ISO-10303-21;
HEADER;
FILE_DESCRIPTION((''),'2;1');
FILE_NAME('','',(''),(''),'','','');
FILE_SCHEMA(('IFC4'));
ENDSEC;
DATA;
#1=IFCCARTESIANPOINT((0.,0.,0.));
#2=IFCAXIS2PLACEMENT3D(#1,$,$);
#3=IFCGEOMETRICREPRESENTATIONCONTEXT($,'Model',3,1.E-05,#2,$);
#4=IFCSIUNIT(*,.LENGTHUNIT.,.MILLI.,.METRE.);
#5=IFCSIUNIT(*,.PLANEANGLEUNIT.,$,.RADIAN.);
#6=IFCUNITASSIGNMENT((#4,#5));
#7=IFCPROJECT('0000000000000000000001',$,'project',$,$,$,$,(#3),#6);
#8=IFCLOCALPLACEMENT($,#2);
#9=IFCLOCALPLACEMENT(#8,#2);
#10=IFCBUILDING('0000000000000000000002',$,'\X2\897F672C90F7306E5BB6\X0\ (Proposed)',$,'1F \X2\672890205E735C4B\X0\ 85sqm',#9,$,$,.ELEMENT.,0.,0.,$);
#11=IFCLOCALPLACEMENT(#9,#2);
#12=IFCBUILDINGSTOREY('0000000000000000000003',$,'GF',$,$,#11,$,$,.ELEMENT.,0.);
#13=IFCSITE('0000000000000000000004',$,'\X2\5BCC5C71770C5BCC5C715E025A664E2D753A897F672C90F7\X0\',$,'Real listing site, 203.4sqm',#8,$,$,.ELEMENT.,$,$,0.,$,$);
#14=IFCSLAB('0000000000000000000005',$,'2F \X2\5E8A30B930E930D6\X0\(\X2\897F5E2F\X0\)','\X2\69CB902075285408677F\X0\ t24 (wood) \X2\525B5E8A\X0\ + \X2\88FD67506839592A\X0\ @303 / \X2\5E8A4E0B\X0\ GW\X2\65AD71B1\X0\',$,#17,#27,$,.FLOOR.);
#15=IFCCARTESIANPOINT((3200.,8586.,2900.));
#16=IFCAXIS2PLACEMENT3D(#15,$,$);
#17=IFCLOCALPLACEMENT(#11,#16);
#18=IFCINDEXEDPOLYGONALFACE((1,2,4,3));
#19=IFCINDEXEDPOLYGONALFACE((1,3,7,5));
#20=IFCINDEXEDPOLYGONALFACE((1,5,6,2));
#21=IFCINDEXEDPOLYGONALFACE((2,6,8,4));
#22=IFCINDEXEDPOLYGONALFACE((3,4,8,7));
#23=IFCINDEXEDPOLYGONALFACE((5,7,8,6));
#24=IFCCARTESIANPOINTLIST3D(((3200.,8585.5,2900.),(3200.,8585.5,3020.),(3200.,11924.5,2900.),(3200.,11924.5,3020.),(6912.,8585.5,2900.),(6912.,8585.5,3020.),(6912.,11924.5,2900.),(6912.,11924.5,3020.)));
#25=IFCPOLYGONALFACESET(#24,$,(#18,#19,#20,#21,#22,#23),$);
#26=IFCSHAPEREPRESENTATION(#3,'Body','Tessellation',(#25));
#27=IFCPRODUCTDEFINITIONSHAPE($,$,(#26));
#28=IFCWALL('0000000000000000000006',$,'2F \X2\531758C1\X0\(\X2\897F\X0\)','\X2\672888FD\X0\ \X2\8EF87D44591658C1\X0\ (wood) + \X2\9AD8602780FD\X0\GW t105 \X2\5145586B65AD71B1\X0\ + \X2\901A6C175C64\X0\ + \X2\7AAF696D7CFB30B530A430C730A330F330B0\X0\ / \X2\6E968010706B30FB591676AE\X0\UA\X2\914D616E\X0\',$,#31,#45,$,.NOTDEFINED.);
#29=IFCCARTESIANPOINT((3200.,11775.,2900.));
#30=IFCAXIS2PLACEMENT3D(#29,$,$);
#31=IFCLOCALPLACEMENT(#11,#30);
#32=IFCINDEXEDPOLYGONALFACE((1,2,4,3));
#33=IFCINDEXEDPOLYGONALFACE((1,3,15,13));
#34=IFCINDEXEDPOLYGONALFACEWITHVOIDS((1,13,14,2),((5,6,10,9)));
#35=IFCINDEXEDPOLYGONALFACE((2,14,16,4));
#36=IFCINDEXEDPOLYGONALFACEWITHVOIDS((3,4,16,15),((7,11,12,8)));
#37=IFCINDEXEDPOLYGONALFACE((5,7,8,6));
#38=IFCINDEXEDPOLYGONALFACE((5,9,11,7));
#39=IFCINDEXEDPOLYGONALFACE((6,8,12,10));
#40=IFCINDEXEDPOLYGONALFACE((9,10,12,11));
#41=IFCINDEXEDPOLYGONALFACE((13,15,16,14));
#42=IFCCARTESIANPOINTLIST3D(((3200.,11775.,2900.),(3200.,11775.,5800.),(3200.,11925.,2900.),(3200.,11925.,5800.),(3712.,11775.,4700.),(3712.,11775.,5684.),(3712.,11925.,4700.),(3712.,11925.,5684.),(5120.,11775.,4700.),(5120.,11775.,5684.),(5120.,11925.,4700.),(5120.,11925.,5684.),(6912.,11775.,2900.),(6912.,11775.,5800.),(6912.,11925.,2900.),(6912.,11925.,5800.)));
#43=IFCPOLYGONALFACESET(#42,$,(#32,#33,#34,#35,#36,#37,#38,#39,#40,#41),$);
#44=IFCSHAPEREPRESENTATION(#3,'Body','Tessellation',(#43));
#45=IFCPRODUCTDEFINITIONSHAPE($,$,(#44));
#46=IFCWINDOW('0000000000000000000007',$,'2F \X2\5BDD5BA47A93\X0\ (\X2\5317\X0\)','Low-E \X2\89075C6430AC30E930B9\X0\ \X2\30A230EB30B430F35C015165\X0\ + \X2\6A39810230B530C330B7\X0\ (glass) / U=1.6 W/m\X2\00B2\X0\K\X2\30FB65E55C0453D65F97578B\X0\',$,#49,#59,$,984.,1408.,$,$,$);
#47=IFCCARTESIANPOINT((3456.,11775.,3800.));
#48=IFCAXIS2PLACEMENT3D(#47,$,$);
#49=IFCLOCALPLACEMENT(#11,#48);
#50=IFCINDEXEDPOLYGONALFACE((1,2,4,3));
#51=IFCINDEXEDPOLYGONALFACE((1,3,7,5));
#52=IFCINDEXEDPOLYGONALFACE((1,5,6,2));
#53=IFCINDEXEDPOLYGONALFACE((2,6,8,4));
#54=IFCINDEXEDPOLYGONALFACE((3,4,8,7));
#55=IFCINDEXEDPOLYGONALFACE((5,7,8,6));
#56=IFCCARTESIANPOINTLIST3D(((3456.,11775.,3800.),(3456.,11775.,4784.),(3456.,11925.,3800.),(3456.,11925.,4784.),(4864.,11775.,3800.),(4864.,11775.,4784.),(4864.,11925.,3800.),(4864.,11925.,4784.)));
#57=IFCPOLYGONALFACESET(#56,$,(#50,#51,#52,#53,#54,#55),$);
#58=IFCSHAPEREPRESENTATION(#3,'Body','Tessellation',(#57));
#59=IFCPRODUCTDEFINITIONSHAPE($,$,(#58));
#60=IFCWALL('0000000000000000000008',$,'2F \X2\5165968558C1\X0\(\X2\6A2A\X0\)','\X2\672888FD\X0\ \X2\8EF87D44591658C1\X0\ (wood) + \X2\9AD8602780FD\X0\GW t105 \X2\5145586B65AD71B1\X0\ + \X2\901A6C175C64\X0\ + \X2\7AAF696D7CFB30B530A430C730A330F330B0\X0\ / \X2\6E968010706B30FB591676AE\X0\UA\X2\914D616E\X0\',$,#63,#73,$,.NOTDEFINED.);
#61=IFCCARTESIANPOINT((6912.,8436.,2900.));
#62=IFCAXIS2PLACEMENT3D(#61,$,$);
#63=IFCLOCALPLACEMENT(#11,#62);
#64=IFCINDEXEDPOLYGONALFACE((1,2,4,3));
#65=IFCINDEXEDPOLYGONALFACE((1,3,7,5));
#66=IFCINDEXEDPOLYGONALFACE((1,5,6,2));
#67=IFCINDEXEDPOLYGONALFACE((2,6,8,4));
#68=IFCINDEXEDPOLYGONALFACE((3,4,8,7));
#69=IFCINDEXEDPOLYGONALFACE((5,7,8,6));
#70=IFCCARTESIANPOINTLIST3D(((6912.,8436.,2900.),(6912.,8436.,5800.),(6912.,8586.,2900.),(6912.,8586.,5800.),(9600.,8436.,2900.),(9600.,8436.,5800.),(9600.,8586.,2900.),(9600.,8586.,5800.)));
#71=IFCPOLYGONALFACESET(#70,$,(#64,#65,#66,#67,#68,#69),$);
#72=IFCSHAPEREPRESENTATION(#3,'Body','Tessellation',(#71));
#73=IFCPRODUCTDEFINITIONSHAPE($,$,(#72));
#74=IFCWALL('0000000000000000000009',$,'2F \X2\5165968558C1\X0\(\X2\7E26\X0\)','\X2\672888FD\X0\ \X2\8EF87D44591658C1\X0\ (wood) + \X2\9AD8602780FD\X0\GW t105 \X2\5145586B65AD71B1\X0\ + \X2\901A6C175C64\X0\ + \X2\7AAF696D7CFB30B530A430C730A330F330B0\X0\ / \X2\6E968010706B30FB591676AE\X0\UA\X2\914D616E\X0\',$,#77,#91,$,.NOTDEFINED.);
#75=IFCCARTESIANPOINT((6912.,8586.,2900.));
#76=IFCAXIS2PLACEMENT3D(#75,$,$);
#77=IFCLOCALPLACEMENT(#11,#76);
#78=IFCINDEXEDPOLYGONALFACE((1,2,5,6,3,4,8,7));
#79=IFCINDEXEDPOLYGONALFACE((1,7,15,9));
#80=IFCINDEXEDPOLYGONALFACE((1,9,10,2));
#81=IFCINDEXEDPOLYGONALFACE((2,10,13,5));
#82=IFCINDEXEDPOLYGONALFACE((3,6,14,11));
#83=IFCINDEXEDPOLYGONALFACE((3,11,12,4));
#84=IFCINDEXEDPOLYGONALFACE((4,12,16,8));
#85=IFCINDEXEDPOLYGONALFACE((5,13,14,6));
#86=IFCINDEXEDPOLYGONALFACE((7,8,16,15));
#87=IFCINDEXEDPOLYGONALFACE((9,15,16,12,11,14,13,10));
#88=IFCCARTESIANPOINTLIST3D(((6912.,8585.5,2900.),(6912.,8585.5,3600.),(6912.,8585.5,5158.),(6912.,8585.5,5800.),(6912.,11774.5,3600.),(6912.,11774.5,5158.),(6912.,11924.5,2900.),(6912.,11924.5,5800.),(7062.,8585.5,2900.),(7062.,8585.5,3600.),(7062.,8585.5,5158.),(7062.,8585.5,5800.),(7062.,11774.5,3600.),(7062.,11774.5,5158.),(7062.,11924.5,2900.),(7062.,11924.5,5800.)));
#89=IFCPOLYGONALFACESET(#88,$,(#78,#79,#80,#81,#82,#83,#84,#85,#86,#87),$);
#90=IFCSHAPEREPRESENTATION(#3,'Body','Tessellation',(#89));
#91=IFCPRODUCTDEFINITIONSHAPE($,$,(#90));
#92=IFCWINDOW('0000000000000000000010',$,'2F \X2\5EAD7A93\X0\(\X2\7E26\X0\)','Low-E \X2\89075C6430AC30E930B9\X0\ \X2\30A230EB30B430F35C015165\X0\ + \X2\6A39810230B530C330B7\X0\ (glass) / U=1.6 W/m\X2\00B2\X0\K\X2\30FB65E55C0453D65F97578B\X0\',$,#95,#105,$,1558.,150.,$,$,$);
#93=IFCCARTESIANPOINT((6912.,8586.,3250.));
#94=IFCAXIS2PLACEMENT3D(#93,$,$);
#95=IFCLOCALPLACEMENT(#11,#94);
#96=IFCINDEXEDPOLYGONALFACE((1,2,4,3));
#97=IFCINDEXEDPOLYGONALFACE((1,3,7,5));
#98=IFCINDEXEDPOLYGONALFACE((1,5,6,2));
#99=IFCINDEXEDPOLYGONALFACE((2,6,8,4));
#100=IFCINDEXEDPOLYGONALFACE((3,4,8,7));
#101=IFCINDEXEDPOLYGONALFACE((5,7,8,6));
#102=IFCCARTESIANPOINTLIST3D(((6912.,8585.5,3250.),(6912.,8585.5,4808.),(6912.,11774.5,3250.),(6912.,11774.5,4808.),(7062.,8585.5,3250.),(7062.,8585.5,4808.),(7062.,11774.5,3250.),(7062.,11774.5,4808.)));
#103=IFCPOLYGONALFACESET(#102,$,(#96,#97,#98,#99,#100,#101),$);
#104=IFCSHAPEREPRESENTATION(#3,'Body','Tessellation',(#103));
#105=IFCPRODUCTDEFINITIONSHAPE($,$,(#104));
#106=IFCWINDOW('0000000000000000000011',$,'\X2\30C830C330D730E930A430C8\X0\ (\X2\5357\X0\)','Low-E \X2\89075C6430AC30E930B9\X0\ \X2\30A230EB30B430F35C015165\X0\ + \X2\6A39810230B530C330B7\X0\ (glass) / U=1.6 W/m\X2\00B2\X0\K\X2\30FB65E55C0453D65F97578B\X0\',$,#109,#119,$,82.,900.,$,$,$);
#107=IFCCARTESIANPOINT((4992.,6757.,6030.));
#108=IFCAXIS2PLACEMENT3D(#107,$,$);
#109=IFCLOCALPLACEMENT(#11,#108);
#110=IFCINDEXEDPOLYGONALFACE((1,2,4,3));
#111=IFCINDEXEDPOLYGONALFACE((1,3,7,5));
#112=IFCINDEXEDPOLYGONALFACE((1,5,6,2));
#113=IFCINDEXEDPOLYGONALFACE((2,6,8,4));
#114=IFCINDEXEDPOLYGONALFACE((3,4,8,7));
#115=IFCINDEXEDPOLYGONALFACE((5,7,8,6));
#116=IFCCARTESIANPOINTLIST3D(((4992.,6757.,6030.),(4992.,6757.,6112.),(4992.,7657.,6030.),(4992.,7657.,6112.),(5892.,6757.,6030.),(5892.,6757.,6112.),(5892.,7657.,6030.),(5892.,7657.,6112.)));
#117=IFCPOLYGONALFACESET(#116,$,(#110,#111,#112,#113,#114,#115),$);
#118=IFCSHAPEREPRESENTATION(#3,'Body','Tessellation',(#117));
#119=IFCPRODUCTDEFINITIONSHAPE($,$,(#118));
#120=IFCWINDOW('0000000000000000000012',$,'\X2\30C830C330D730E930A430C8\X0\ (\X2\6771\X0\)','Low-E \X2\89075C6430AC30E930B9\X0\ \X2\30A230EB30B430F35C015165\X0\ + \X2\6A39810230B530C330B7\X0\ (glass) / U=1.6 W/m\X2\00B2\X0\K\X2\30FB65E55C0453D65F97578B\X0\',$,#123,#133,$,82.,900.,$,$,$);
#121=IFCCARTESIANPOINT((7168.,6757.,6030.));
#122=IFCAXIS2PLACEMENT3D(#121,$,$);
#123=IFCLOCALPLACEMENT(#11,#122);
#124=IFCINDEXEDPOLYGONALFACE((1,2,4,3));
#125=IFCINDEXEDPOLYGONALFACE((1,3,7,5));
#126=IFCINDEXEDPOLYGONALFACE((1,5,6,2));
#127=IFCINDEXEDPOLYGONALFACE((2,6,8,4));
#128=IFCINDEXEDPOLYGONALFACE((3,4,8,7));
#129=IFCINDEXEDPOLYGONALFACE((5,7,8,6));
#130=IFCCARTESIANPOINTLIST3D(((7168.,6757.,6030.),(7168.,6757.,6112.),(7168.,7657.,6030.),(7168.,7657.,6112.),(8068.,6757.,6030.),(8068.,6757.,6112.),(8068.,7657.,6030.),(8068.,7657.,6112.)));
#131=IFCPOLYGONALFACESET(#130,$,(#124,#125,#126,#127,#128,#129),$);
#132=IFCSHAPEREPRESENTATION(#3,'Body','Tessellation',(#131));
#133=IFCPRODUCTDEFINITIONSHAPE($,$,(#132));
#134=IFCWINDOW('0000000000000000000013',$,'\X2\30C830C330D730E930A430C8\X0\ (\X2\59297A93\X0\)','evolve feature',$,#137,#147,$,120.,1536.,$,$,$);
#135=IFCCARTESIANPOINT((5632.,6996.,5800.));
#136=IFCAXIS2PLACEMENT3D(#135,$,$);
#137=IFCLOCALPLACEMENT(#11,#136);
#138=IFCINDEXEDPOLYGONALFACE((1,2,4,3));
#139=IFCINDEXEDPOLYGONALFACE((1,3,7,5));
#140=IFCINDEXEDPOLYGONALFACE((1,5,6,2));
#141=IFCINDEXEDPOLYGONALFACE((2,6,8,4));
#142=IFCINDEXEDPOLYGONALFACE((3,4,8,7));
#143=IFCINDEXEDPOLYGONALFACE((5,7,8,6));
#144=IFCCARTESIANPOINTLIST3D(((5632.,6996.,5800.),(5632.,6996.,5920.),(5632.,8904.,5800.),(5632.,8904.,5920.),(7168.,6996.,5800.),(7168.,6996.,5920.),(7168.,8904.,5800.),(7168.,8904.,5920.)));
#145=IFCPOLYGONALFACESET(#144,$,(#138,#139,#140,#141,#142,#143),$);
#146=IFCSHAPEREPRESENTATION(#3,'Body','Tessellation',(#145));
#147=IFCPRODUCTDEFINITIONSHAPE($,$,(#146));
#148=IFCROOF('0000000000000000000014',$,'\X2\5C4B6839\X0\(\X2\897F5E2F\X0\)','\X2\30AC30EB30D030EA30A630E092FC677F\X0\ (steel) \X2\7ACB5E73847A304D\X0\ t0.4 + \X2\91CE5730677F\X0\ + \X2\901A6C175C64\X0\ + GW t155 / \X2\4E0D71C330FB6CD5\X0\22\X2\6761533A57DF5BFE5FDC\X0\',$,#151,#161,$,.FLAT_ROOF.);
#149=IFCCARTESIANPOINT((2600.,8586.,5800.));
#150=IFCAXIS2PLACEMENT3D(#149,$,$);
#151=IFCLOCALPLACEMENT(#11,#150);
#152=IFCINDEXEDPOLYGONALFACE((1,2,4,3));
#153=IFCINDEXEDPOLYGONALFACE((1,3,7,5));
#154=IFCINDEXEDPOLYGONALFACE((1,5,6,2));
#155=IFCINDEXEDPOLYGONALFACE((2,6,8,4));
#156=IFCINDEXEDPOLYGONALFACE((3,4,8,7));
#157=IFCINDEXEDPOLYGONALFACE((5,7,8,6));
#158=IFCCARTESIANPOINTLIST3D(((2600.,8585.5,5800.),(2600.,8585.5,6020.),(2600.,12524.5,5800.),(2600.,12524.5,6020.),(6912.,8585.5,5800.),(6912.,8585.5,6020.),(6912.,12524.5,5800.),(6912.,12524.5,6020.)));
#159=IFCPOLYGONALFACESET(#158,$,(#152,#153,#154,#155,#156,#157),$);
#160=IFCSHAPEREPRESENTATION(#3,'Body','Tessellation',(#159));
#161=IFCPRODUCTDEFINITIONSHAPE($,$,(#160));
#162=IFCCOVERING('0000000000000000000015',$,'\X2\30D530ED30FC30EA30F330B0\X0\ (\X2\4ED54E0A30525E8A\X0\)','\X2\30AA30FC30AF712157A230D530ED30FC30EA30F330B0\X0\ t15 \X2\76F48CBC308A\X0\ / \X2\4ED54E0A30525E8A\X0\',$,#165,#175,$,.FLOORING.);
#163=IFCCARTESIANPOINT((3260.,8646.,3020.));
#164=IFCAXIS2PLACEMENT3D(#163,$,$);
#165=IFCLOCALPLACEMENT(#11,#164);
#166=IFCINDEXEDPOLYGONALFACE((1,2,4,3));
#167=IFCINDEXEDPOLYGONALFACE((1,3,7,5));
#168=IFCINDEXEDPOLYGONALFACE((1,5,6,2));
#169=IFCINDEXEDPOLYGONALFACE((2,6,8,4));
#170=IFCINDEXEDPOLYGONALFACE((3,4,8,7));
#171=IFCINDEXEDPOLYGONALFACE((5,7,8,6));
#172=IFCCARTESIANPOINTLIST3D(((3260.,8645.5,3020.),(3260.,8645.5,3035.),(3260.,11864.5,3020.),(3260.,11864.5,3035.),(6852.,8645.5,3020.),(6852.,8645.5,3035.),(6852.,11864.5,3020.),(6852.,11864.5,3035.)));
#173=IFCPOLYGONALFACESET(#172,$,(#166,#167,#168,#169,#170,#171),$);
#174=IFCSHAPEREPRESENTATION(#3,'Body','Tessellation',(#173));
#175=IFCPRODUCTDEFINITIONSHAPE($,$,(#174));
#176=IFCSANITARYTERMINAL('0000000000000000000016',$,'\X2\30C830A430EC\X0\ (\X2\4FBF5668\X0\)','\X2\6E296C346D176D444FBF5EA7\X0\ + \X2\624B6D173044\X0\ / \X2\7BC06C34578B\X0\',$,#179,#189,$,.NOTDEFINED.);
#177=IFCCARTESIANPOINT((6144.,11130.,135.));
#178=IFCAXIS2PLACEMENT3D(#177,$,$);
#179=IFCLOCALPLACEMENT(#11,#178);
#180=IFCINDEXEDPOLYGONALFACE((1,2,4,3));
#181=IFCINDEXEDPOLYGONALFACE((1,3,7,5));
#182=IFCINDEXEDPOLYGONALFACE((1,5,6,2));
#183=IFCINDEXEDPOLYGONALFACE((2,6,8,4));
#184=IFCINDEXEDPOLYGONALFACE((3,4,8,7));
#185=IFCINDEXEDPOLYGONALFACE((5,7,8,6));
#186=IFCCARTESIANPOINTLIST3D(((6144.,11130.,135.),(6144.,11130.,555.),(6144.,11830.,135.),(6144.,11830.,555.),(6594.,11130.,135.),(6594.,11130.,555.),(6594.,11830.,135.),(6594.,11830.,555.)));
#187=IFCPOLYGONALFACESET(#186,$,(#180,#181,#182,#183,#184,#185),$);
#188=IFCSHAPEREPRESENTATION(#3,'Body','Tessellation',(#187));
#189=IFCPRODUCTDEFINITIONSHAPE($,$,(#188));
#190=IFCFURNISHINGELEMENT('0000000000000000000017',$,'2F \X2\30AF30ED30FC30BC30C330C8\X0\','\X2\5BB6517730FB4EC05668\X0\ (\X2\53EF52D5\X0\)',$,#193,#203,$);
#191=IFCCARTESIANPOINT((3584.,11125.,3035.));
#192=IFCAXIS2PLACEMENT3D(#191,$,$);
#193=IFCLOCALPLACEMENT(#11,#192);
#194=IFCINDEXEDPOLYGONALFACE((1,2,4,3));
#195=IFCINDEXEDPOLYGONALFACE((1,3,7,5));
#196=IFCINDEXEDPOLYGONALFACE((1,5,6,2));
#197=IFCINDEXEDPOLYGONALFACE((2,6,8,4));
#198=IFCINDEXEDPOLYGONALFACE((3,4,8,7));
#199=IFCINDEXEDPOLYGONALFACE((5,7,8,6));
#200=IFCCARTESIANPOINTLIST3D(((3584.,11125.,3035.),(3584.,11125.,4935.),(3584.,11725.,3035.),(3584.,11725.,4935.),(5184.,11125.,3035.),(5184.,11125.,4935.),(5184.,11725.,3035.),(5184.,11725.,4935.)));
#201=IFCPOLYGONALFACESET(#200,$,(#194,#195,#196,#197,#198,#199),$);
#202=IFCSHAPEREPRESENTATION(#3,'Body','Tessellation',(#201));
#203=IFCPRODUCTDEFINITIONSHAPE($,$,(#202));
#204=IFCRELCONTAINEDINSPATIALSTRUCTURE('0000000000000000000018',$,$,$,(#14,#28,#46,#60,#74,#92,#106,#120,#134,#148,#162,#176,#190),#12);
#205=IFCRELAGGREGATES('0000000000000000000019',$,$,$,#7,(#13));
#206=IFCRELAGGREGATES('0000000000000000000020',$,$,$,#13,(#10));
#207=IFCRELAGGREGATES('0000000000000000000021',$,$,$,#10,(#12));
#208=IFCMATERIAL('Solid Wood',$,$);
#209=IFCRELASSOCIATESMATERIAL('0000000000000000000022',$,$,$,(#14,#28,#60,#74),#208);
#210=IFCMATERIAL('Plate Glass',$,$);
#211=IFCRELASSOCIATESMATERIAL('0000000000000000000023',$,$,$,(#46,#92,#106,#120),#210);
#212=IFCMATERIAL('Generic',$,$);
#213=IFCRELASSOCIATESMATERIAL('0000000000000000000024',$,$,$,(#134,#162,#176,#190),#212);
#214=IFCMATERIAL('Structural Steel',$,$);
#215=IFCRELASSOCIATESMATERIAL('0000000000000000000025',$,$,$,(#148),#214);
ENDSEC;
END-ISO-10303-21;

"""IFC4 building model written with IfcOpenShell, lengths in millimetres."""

from ifc_helpers import new_model, si_unit, frame, frame_2d, origin, place, context, project, spatial, rectangle, extrude, material, element, fill, save


model = new_model("IFC4")

# Units and contexts
model_context = context("Model", 3, precision=1e-05, world=origin())
ifc_project = project(units=[si_unit("LENGTHUNIT", "METRE", prefix="MILLI"), si_unit("PLANEANGLEUNIT", "RADIAN")], contexts=[model_context])

# Site, building, storey
site_placement = place(None, origin())
site = spatial("IfcSite", under=ifc_project, at=site_placement, Name="富山県富山市婦中町西本郷", ObjectType="Real listing site, 203.4sqm", CompositionType="ELEMENT", RefElevation=0.0)
building_placement = place(site_placement, origin())
building = spatial("IfcBuilding", under=site, at=building_placement, Name="西本郷の家 (Proposed)", ObjectType="1F 木造平屋 85sqm", CompositionType="ELEMENT", ElevationOfRefHeight=0.0, ElevationOfTerrain=0.0)
storey_placement = place(building_placement, origin())
storey = spatial("IfcBuildingStorey", under=building, at=storey_placement, Name="GF", CompositionType="ELEMENT", Elevation=0.0)

# Slab
ifc_material_1 = material(Name="Solid Wood")
slab_placement = place(storey_placement, frame((3200.0, 8586.0, 2900.0)))
element("IfcSlab", 1, at=slab_placement, inside=storey, material=ifc_material_1, Name="2F 床スラブ(西帯)", Description="構造用合板 t24 (wood) 剛床 + 製材根太 @303 / 床下 GW断熱", PredefinedType="FLOOR", context=model_context, shape_type="SweptSolid", body=[
    extrude(rectangle(XDim=3712.0, YDim=3339.0, at=frame_2d((1856.0, 1669.0))), frame((3200.0, 8586.0, 2900.0)), (0.0, 0.0, 1.0), 120.0),
])

# Wall, opening, window
wall_1_placement = place(storey_placement, frame((3200.0, 11775.0, 2900.0)))
wall_1 = element("IfcWall", 2, at=wall_1_placement, inside=storey, material=ifc_material_1, Name="2F 北壁(西)", Description="木製 軸組外壁 (wood) + 高性能GW t105 充填断熱 + 通気層 + 窯業系サイディング / 準耐火・外皮UA配慮", PredefinedType="NOTDEFINED", context=model_context, shape_type="SweptSolid", body=[
    extrude(rectangle(XDim=3712.0, YDim=150.0, at=frame_2d((1856.0, 75.0))), frame((3200.0, 11775.0, 2900.0)), (0.0, 0.0, 1.0), 2900.0),
])
opening_1_placement = place(storey_placement, frame((3456.0, 11775.0, 3800.0)))
opening_1 = element("IfcOpeningElement", 3, at=opening_1_placement, cuts=wall_1, PredefinedType="NOTDEFINED", context=model_context, shape_type="SweptSolid", body=[
    extrude(rectangle(XDim=1408.0, YDim=150.0, at=frame_2d((704.0, 75.0))), frame((3456.0, 11775.0, 3800.0)), (0.0, 0.0, 1.0), 984.0),
])
ifc_material_2 = material(Name="Plate Glass")
window_1_placement = place(storey_placement, frame((3456.0, 11775.0, 3800.0)))
window_1 = element("IfcWindow", 4, at=window_1_placement, inside=storey, material=ifc_material_2, Name="2F 寝室窓 (北)", Description="Low-E 複層ガラス アルゴン封入 + 樹脂サッシ (glass) / U=1.6 W/m²K・日射取得型", OverallHeight=984.0, OverallWidth=1408.0, context=model_context, shape_type="SweptSolid", body=[
    extrude(rectangle(XDim=1408.0, YDim=150.0, at=frame_2d((704.0, 75.0))), frame((3456.0, 11775.0, 3800.0)), (0.0, 0.0, 1.0), 984.0),
])
fill(opening_1, window_1)

# Wall
wall_2_placement = place(storey_placement, frame((6912.0, 8436.0, 2900.0)))
element("IfcWall", 5, at=wall_2_placement, inside=storey, material=ifc_material_1, Name="2F 入隅壁(横)", Description="木製 軸組外壁 (wood) + 高性能GW t105 充填断熱 + 通気層 + 窯業系サイディング / 準耐火・外皮UA配慮", PredefinedType="NOTDEFINED", context=model_context, shape_type="SweptSolid", body=[
    extrude(rectangle(XDim=2688.0, YDim=150.0, at=frame_2d((1344.0, 75.0))), frame((6912.0, 8436.0, 2900.0)), (0.0, 0.0, 1.0), 2900.0),
])

# Wall, opening, window
wall_3_placement = place(storey_placement, frame((6912.0, 8586.0, 2900.0)))
wall_3 = element("IfcWall", 6, at=wall_3_placement, inside=storey, material=ifc_material_1, Name="2F 入隅壁(縦)", Description="木製 軸組外壁 (wood) + 高性能GW t105 充填断熱 + 通気層 + 窯業系サイディング / 準耐火・外皮UA配慮", PredefinedType="NOTDEFINED", context=model_context, shape_type="SweptSolid", body=[
    extrude(rectangle(XDim=150.0, YDim=3339.0, at=frame_2d((75.0, 1669.0))), frame((6912.0, 8586.0, 2900.0)), (0.0, 0.0, 1.0), 2900.0),
])
opening_2_placement = place(storey_placement, frame((6912.0, 8586.0, 3250.0)))
opening_2 = element("IfcOpeningElement", 7, at=opening_2_placement, cuts=wall_3, PredefinedType="NOTDEFINED", context=model_context, shape_type="SweptSolid", body=[
    extrude(rectangle(XDim=150.0, YDim=3189.0, at=frame_2d((75.0, 1594.0))), frame((6912.0, 8586.0, 3250.0)), (0.0, 0.0, 1.0), 1558.0),
])
window_2_placement = place(storey_placement, frame((6912.0, 8586.0, 3250.0)))
window_2 = element("IfcWindow", 8, at=window_2_placement, inside=storey, material=ifc_material_2, Name="2F 庭窓(縦)", Description="Low-E 複層ガラス アルゴン封入 + 樹脂サッシ (glass) / U=1.6 W/m²K・日射取得型", OverallHeight=1558.0, OverallWidth=150.0, context=model_context, shape_type="SweptSolid", body=[
    extrude(rectangle(XDim=150.0, YDim=3189.0, at=frame_2d((75.0, 1594.0))), frame((6912.0, 8586.0, 3250.0)), (0.0, 0.0, 1.0), 1558.0),
])
fill(opening_2, window_2)

# Windows
window_3_placement = place(storey_placement, frame((4992.0, 6757.0, 6030.0)))
element("IfcWindow", 9, at=window_3_placement, inside=storey, material=ifc_material_2, Name="トップライト (南)", Description="Low-E 複層ガラス アルゴン封入 + 樹脂サッシ (glass) / U=1.6 W/m²K・日射取得型", OverallHeight=82.0, OverallWidth=900.0, context=model_context, shape_type="SweptSolid", body=[
    extrude(rectangle(XDim=900.0, YDim=900.0, at=frame_2d((450.0, 450.0))), frame((4992.0, 6757.0, 6030.0)), (0.0, 0.0, 1.0), 82.0),
])
window_4_placement = place(storey_placement, frame((7168.0, 6757.0, 6030.0)))
element("IfcWindow", 10, at=window_4_placement, inside=storey, material=ifc_material_2, Name="トップライト (東)", Description="Low-E 複層ガラス アルゴン封入 + 樹脂サッシ (glass) / U=1.6 W/m²K・日射取得型", OverallHeight=82.0, OverallWidth=900.0, context=model_context, shape_type="SweptSolid", body=[
    extrude(rectangle(XDim=900.0, YDim=900.0, at=frame_2d((450.0, 450.0))), frame((7168.0, 6757.0, 6030.0)), (0.0, 0.0, 1.0), 82.0),
])
ifc_material_3 = material(Name="Generic")
window_5_placement = place(storey_placement, frame((5632.0, 6996.0, 5800.0)))
element("IfcWindow", 11, at=window_5_placement, inside=storey, material=ifc_material_3, Name="トップライト (天窓)", Description="evolve feature", OverallHeight=120.0, OverallWidth=1536.0, context=model_context, shape_type="SweptSolid", body=[
    extrude(rectangle(XDim=1536.0, YDim=1908.0, at=frame_2d((768.0, 954.0))), frame((5632.0, 6996.0, 5800.0)), (0.0, 0.0, 1.0), 120.0),
])

# Roof
ifc_material_4 = material(Name="Structural Steel")
for number, where, name in (
    (12, (2600.0, 8586.0, 5800.0), "屋根(西帯)"),
):
    element("IfcRoof", number, at=place(storey_placement, frame(where)), inside=storey, material=ifc_material_4, Name=name, Description="ガルバリウム鋼板 (steel) 立平葺き t0.4 + 野地板 + 通気層 + GW t155 / 不燃・法22条区域対応", PredefinedType="FLAT_ROOF", context=model_context, shape_type="SweptSolid", body=[
        extrude(rectangle(XDim=4312.0, YDim=3939.0, at=frame_2d((2156.0, 1969.0))), frame((2600.0, 8586.0, 5800.0)), (0.0, 0.0, 1.0), 220.0),
    ])

# Covering
covering_placement = place(storey_placement, frame((3260.0, 8646.0, 3020.0)))
element("IfcCovering", 13, at=covering_placement, inside=storey, material=ifc_material_3, Name="フローリング (仕上げ床)", Description="オーク無垢フローリング t15 直貼り / 仕上げ床", PredefinedType="FLOORING", context=model_context, shape_type="SweptSolid", body=[
    extrude(rectangle(XDim=3592.0, YDim=3219.0, at=frame_2d((1796.0, 1609.0))), frame((3260.0, 8646.0, 3020.0)), (0.0, 0.0, 1.0), 15.0),
])

# Sanitary terminal
sanitary_terminal_placement = place(storey_placement, frame((6144.0, 11130.0, 135.0)))
element("IfcSanitaryTerminal", 14, at=sanitary_terminal_placement, inside=storey, material=ifc_material_3, Name="トイレ (便器)", Description="温水洗浄便座 + 手洗い / 節水型", PredefinedType="NOTDEFINED", context=model_context, shape_type="SweptSolid", body=[
    extrude(rectangle(XDim=450.0, YDim=700.0, at=frame_2d((225.0, 350.0))), frame((6144.0, 11130.0, 135.0)), (0.0, 0.0, 1.0), 420.0),
])

# Furnishing element
furnishing_1_placement = place(storey_placement, frame((3584.0, 11125.0, 3035.0)))
element("IfcFurnishingElement", 15, at=furnishing_1_placement, inside=storey, material=ifc_material_3, Name="2F クローゼット", Description="家具・什器 (可動)", context=model_context, shape_type="SweptSolid", body=[
    extrude(rectangle(XDim=1600.0, YDim=600.0, at=frame_2d((800.0, 300.0))), frame((3584.0, 11125.0, 3035.0)), (0.0, 0.0, 1.0), 1900.0),
])

save(model, "model.ifc")
